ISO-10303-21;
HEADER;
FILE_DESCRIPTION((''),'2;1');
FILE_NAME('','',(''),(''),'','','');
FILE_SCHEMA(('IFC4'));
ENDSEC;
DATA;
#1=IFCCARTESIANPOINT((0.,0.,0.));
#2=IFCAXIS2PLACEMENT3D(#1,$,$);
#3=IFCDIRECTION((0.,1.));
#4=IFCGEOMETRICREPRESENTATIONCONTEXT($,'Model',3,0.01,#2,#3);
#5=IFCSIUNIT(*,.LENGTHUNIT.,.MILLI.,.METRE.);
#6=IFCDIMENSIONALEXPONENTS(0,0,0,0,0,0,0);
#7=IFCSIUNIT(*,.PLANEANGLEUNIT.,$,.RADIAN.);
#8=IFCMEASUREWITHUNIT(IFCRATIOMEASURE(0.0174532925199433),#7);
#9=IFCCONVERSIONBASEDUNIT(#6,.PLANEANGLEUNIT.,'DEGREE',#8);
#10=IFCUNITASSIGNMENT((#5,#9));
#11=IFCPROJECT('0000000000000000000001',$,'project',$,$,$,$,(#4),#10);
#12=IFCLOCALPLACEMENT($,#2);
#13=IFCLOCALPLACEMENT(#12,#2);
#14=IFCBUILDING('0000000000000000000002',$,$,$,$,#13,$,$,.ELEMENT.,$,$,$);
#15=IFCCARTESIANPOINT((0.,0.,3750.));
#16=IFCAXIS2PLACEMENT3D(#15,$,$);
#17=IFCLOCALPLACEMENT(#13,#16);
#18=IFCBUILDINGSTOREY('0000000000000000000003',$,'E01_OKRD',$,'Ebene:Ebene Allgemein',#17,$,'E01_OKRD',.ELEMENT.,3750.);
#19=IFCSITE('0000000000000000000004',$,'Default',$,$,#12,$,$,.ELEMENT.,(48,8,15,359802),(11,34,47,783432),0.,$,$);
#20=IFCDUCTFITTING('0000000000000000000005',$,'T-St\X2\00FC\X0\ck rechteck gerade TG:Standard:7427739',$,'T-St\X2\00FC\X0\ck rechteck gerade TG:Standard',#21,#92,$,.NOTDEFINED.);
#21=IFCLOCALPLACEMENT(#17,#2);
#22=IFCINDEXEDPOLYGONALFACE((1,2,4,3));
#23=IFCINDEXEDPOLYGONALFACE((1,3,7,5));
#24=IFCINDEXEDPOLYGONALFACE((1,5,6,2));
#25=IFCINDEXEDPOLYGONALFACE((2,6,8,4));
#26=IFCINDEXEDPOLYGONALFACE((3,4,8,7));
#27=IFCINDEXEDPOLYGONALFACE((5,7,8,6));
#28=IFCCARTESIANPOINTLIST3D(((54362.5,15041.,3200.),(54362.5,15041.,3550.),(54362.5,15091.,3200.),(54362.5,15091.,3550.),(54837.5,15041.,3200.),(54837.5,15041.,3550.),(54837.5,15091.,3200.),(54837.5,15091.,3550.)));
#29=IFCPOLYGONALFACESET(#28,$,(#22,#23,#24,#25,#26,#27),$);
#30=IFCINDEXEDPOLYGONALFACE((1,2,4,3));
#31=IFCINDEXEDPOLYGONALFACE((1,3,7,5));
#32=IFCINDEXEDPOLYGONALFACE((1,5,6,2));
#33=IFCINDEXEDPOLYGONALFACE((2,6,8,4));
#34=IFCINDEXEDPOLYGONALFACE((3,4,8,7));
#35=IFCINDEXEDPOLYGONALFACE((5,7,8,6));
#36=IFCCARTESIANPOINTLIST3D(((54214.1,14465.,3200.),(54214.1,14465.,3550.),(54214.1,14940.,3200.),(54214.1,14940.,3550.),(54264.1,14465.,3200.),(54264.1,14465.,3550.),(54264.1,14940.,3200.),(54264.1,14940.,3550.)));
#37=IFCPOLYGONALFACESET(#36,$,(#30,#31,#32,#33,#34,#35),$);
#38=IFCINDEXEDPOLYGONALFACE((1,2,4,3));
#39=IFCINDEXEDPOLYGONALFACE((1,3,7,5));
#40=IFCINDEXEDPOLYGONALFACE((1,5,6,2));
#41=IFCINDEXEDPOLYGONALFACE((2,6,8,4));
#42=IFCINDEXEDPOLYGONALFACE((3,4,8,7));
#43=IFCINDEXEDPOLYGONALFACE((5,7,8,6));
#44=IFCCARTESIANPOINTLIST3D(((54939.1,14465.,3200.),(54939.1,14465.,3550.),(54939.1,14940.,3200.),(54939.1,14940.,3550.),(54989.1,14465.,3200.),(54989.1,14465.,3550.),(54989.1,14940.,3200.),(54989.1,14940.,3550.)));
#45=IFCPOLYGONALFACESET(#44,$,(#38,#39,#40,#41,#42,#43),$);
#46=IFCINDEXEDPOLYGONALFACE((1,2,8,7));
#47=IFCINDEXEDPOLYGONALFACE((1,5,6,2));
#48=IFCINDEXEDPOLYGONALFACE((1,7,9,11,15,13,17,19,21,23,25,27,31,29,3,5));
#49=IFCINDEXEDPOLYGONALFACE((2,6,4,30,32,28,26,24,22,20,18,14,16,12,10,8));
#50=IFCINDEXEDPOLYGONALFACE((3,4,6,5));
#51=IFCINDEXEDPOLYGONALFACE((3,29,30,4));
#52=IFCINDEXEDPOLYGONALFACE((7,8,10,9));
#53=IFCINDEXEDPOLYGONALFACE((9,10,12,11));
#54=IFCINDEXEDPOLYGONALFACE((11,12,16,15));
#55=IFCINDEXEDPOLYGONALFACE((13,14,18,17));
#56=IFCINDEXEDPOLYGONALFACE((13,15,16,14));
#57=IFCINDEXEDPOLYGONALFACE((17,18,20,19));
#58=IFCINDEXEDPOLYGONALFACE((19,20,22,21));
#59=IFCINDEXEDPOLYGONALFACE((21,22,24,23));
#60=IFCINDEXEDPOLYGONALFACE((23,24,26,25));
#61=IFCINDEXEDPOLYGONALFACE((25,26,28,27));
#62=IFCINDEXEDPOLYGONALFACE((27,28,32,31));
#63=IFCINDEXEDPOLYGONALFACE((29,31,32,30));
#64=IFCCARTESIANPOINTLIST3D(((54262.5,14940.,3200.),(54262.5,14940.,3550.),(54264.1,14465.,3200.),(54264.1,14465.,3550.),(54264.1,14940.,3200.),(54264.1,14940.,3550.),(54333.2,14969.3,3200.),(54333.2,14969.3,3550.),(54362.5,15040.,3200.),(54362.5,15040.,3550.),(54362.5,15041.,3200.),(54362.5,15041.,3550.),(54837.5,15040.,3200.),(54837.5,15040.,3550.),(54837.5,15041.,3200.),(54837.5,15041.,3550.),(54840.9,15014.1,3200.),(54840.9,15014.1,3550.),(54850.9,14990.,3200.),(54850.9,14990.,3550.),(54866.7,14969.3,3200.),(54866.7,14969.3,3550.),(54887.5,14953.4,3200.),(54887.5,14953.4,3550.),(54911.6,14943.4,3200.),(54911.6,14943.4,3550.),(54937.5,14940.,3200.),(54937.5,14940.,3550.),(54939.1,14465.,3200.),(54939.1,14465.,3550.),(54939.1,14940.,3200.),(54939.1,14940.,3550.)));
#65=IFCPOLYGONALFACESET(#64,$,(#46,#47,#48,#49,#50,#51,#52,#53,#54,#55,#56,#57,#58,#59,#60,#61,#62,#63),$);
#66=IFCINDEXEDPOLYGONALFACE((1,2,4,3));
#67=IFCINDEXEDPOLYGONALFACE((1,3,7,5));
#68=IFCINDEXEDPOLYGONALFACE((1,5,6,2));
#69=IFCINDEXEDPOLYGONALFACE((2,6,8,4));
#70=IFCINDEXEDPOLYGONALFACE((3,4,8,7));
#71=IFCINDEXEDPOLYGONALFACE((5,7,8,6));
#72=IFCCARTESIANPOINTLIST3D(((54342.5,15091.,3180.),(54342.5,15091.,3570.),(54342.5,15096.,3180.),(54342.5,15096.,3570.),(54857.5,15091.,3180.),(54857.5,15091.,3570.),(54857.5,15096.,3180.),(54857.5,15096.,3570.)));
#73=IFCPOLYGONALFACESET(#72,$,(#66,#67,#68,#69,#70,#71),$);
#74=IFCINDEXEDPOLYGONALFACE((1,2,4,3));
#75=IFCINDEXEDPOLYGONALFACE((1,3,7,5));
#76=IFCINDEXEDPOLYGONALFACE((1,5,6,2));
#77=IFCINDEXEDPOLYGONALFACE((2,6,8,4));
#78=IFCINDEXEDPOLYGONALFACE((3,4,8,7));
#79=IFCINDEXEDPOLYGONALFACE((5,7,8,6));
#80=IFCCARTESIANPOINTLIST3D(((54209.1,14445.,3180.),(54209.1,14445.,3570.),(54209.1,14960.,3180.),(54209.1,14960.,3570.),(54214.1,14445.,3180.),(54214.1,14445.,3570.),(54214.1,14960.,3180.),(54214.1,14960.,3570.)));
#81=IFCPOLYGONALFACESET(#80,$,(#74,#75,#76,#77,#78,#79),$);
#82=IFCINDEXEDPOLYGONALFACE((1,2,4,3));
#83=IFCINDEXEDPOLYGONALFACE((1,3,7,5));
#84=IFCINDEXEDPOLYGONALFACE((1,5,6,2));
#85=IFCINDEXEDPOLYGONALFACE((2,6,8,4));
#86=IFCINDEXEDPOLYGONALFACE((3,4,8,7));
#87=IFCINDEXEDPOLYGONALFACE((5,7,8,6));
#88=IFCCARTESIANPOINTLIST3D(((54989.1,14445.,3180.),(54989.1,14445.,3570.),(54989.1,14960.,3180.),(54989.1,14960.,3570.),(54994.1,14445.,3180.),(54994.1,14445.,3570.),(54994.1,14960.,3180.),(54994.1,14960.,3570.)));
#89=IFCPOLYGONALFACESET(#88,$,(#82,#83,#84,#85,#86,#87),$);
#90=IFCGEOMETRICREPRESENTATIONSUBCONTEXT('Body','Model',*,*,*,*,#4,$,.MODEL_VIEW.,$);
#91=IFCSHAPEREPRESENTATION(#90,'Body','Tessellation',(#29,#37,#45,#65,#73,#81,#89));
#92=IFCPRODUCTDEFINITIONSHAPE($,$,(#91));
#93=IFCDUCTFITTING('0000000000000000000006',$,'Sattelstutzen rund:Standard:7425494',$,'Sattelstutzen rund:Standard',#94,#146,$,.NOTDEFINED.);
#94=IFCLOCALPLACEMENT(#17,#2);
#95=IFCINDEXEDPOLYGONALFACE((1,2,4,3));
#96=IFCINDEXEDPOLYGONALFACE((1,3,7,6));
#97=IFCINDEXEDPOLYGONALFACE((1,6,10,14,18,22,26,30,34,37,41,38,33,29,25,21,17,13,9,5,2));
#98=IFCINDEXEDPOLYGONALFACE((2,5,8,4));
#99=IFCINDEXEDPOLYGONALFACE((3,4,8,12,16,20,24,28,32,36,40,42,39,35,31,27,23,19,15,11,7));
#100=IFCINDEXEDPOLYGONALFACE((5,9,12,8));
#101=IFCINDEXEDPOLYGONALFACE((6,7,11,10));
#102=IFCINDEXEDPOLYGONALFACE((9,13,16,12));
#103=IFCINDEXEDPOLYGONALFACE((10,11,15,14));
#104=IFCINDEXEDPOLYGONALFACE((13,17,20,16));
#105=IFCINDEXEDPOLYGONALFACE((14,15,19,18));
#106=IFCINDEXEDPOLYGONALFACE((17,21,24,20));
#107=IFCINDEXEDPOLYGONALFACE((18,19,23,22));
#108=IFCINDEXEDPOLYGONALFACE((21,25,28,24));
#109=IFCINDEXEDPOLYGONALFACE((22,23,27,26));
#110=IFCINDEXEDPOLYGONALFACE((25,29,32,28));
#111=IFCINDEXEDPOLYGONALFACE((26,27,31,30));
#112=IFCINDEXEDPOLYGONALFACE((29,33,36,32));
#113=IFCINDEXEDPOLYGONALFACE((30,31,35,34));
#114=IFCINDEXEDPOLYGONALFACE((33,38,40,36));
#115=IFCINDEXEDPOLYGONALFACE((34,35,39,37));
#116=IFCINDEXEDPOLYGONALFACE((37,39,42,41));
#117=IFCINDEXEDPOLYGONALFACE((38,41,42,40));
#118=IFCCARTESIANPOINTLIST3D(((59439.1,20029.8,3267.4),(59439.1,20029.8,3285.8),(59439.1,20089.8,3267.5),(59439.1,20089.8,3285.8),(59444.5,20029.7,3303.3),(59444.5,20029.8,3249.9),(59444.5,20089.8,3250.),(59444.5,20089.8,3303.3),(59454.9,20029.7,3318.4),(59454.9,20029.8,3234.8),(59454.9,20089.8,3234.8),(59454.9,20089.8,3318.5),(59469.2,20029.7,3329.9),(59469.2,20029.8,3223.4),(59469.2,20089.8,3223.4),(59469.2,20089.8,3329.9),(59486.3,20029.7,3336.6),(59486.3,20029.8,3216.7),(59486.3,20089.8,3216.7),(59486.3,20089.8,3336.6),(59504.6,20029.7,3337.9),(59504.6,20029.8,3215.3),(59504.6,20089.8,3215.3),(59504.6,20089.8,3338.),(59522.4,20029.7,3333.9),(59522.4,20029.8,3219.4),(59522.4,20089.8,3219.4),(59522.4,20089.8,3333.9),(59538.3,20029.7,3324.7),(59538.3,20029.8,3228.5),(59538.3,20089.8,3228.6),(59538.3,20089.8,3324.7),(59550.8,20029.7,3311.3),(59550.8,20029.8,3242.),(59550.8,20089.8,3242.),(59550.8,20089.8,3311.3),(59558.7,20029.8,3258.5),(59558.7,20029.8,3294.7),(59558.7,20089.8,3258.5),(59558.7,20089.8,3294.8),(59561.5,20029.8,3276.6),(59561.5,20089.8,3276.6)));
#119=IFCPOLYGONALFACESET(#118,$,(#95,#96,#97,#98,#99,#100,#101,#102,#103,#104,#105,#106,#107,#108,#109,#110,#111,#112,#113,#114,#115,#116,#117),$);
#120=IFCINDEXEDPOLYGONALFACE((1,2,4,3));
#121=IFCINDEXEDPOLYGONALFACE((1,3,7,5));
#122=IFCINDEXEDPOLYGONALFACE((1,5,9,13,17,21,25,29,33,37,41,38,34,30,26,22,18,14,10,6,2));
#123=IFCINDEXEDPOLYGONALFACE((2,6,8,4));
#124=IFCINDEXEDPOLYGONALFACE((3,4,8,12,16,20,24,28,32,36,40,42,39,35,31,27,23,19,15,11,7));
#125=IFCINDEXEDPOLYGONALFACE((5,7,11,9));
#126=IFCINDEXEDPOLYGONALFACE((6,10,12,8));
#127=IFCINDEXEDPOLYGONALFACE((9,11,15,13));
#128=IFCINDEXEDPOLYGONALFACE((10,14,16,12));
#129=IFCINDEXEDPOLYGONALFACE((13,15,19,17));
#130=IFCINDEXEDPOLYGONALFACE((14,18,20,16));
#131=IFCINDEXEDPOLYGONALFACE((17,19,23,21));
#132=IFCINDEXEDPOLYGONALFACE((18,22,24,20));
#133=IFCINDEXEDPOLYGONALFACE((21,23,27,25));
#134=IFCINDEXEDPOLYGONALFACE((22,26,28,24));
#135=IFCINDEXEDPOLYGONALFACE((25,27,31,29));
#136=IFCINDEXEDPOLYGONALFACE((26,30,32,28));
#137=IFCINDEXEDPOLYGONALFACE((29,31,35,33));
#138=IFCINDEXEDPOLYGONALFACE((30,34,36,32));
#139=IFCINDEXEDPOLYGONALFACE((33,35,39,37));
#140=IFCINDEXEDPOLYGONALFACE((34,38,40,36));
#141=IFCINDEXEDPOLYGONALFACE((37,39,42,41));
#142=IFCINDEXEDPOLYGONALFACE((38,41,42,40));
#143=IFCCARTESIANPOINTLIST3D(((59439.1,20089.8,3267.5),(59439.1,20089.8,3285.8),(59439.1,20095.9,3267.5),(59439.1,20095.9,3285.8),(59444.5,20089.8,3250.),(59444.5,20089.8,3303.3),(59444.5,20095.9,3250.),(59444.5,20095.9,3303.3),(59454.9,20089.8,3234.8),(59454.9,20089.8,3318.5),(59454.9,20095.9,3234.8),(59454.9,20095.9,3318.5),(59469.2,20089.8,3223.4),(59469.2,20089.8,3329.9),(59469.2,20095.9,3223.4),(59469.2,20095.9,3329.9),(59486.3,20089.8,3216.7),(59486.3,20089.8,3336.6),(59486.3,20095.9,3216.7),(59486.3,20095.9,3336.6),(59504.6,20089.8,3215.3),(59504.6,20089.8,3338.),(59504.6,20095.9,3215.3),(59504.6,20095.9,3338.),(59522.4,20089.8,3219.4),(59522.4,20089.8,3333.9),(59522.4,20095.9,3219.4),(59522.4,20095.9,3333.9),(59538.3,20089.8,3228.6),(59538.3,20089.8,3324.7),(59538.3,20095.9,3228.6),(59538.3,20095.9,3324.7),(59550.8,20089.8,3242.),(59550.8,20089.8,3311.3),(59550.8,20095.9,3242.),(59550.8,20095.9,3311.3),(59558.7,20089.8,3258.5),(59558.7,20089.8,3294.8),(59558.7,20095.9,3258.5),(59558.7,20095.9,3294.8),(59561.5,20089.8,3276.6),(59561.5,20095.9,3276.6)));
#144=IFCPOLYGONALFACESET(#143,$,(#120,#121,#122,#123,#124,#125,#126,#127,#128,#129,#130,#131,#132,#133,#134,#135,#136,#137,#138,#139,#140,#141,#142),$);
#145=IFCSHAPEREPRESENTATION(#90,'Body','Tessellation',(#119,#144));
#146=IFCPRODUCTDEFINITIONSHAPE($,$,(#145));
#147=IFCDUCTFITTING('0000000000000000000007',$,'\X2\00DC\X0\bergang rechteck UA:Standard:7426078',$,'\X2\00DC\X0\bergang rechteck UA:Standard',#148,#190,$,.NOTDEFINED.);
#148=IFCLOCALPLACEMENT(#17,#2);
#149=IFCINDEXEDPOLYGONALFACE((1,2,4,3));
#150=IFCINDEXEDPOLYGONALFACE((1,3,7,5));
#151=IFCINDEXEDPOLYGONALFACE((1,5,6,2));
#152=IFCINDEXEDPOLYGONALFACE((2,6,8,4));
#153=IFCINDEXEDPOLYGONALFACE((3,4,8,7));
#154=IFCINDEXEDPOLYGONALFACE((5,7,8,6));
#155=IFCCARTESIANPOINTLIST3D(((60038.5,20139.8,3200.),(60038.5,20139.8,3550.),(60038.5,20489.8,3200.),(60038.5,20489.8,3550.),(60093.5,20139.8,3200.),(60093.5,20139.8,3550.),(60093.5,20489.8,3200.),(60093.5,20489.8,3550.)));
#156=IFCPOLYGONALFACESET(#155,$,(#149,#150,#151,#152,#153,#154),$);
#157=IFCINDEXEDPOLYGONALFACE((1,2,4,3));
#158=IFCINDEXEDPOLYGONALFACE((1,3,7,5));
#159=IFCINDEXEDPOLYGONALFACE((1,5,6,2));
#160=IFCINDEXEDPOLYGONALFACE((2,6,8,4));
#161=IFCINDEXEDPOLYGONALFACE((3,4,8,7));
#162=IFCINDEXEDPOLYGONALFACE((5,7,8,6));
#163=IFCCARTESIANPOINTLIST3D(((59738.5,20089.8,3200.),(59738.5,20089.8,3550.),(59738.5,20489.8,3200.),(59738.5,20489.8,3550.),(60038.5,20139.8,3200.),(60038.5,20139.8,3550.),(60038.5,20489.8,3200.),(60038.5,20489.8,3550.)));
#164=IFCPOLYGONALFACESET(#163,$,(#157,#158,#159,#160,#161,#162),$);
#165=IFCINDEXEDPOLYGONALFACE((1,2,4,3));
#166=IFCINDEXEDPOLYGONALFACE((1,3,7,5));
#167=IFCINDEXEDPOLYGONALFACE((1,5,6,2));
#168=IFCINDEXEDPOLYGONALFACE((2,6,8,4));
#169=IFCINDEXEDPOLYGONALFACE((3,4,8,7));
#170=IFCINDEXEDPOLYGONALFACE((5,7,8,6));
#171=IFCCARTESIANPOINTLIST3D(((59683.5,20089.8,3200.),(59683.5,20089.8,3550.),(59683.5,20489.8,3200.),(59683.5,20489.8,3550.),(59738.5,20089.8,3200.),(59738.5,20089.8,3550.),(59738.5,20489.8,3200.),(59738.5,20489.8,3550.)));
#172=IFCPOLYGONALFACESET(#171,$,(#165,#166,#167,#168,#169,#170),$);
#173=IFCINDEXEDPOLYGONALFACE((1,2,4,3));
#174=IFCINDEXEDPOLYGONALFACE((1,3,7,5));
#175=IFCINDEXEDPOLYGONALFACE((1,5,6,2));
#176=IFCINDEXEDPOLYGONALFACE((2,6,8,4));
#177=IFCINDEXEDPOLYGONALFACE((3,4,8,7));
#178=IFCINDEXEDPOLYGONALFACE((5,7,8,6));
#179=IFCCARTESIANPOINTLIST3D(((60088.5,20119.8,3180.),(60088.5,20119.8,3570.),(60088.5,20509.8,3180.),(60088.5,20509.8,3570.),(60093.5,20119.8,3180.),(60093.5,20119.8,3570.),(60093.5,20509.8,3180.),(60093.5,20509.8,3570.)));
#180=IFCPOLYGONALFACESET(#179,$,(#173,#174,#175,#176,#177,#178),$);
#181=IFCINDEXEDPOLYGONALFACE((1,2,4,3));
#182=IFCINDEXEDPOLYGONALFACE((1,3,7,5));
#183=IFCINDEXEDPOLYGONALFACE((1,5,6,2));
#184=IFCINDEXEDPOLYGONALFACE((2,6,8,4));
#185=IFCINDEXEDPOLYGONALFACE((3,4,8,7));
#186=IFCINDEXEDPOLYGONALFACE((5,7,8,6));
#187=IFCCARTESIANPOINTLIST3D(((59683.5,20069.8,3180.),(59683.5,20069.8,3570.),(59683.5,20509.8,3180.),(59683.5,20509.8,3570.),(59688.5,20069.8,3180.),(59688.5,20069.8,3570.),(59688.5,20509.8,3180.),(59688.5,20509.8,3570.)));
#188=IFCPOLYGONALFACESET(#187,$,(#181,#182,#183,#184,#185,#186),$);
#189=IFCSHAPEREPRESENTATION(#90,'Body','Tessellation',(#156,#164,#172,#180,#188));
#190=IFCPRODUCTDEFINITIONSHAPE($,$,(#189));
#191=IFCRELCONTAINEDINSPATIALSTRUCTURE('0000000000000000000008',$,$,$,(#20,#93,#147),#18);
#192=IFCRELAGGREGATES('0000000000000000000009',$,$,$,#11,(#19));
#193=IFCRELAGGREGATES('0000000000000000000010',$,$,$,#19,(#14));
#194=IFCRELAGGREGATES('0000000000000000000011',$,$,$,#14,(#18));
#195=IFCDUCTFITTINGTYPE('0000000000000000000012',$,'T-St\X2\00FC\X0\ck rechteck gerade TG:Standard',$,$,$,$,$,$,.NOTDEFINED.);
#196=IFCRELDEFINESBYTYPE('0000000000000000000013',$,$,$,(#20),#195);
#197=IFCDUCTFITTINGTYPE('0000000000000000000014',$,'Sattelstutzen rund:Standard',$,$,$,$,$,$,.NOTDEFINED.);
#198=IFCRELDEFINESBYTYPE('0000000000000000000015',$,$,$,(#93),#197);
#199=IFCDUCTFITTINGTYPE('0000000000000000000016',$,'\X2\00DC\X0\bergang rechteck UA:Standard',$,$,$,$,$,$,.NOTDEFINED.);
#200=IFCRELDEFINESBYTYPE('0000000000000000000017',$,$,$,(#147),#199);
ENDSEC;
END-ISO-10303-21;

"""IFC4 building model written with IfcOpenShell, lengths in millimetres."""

from ifc_helpers import new_model, entity, si_unit, converted_unit, direction, frame, frame_2d, origin, origin_2d_with_axis, place, context, subcontext, project, spatial, polyline, circle_curve, parameter, trimmed, segment, composite_curve, rectangle, circle, outline, extrude, source, transform, mapped, type_object, type_shapes, element, save


model = new_model("IFC4")

# Units and contexts
model_context = context("Model", 3, precision=0.01, world=origin(), true_north=direction((0.0, 1.0)))
body_context = subcontext(model_context, "Body", "Model", "MODEL_VIEW")
ifc_project = project(units=[si_unit("LENGTHUNIT", "METRE", prefix="MILLI"), converted_unit("PLANEANGLEUNIT", "DEGREE", entity("IfcRatioMeasure", 0.0174532925199433), si_unit("PLANEANGLEUNIT", "RADIAN"), dimensions=[0, 0, 0, 0, 0, 0, 0])], contexts=[model_context])

# Site, building, storey
site_placement = place(None, origin())
site = spatial("IfcSite", under=ifc_project, at=site_placement, Name="Default", CompositionType="ELEMENT", RefLatitude=(48, 8, 15, 359802), RefLongitude=(11, 34, 47, 783432), RefElevation=0.0)
building_placement = place(site_placement, origin())
building = spatial("IfcBuilding", under=site, at=building_placement, CompositionType="ELEMENT")
storey_placement = place(building_placement, frame((0.0, 0.0, 3750.0)))
storey = spatial("IfcBuildingStorey", under=building, at=storey_placement, Name="E01_OKRD", ObjectType="Ebene:Ebene Allgemein", LongName="E01_OKRD", CompositionType="ELEMENT", Elevation=3750.0)

# Duct fittings
duct_fitting_type_1 = type_object("IfcDuctFittingType", Name="T-Stück rechteck gerade TG:Standard", PredefinedType="NOTDEFINED")
shared_shape_1 = source(origin(), body_context, "Body", "SweptSolid", [
    extrude(rectangle(XDim=50.0, YDim=475.0, at=origin_2d_with_axis()), frame((0.0, -363.5, -175.0), z_axis=(0.0, 0.0, 1.0), x_axis=(0.0, -1.0, 0.0)), (0.0, 0.0, 1.0), 350.0),
    extrude(rectangle(XDim=50.0, YDim=475.0, at=origin_2d_with_axis()), frame((360.9, 0.0, -175.0), z_axis=(0.0, 0.0, 1.0), x_axis=(-1.0, 0.0, 0.0)), (0.0, 0.0, 1.0), 350.0),
    extrude(rectangle(XDim=50.0, YDim=475.0, at=origin_2d_with_axis()), frame((-364.1, 0.0, -175.0)), (0.0, 0.0, 1.0), 350.0),
    extrude(outline(composite_curve([segment(trimmed(circle_curve(frame_2d((-338.1, -154.8), x_axis=(-1.0, 0.0)), 100.0), [parameter(180.0)], [parameter(270.0)], True, "PARAMETER"), False, "CONTINUOUS"), segment(polyline([(-238.1, -154.8), (-238.1, -155.8)]), True, "CONTINUOUS"), segment(polyline([(-238.1, -155.8), (236.9, -155.8)]), True, "CONTINUOUS"), segment(polyline([(236.9, -155.8), (236.9, -154.8)]), True, "CONTINUOUS"), segment(trimmed(circle_curve(frame_2d((336.9, -154.8), x_axis=(-1.0, 0.0)), 100.0), [parameter(270.0)], [parameter(0.0)], True, "PARAMETER"), False, "CONTINUOUS"), segment(polyline([(336.9, -54.8), (338.5, -54.8)]), True, "CONTINUOUS"), segment(polyline([(338.5, -54.8), (338.5, 420.2)]), True, "CONTINUOUS"), segment(polyline([(338.5, 420.2), (-336.5, 420.2)]), True, "CONTINUOUS"), segment(polyline([(-336.5, 420.2), (-336.5, -54.8)]), True, "CONTINUOUS"), segment(polyline([(-336.5, -54.8), (-338.1, -54.8)]), True, "CONTINUOUS")], self_intersect=False)), frame((-0.6, -182.7, -175.0), z_axis=(0.0, 0.0, -1.0), x_axis=(-1.0, 0.0, 0.0)), (0.0, 0.0, -1.0), 350.0),
    extrude(rectangle(XDim=5.0, YDim=515.0, at=origin_2d_with_axis()), frame((0.0, -391.0, -195.0), z_axis=(0.0, 0.0, 1.0), x_axis=(0.0, 1.0, 0.0)), (0.0, 0.0, 1.0), 390.0),
    extrude(rectangle(XDim=5.0, YDim=515.0, at=origin_2d_with_axis()), frame((388.4, 0.0, -195.0), z_axis=(0.0, 0.0, 1.0), x_axis=(-1.0, 0.0, 0.0)), (0.0, 0.0, 1.0), 390.0),
    extrude(rectangle(XDim=5.0, YDim=515.0, at=origin_2d_with_axis()), frame((-391.6, 0.0, -195.0), z_axis=(0.0, 0.0, 1.0), x_axis=(-1.0, 0.0, 0.0)), (0.0, 0.0, 1.0), 390.0),
])
type_shapes(duct_fitting_type_1, [shared_shape_1])
duct_fitting_1_placement = place(storey_placement, frame((54600.0, 14702.5, 3375.0), z_axis=(0.0, 0.0, 1.0), x_axis=(-1.0, 0.0, 0.0)))
element("IfcDuctFitting", 1, at=duct_fitting_1_placement, inside=storey, type_object=duct_fitting_type_1, Name="T-Stück rechteck gerade TG:Standard:7427739", ObjectType="T-Stück rechteck gerade TG:Standard", PredefinedType="NOTDEFINED", context=body_context, shape_type="MappedRepresentation", body=[
    mapped(shared_shape_1, transform((0.0, 0.0, 0.0), scale=1.0)),
])
duct_fitting_type_2 = type_object("IfcDuctFittingType", Name="Sattelstutzen rund:Standard", PredefinedType="NOTDEFINED")
shared_shape_2 = source(origin(), body_context, "Body", "SweptSolid", [
    extrude(circle(Radius=61.5, at=frame_2d((0.0, 0.0), x_axis=(1.0, 0.0))), frame((0.0, 0.0, 0.0), z_axis=(1.0, 0.0, 0.0), x_axis=(0.0, -1.0, 0.0)), (0.0, 0.0, 1.0), 60.0),
    extrude(circle(Radius=61.5, at=frame_2d((0.0, 0.0), x_axis=(1.0, 0.0))), frame((-6.1, 0.0, 0.0), z_axis=(1.0, 0.0, 0.0), x_axis=(0.0, -1.0, 0.0)), (0.0, 0.0, 1.0), 6.1),
])
type_shapes(duct_fitting_type_2, [shared_shape_2])
duct_fitting_2_placement = place(storey_placement, frame((59500.0, 20089.8, 3276.6), z_axis=(0.0, 0.000429, -1.0), x_axis=(0.0, -1.0, -0.000429)))
element("IfcDuctFitting", 2, at=duct_fitting_2_placement, inside=storey, type_object=duct_fitting_type_2, Name="Sattelstutzen rund:Standard:7425494", ObjectType="Sattelstutzen rund:Standard", PredefinedType="NOTDEFINED", context=body_context, shape_type="MappedRepresentation", body=[
    mapped(shared_shape_2, transform((0.0, 0.0, 0.0), scale=1.0)),
])
duct_fitting_type_3 = type_object("IfcDuctFittingType", Name="Übergang rechteck UA:Standard", PredefinedType="NOTDEFINED")
shared_shape_3 = source(origin(), body_context, "Body", "SweptSolid", [
    extrude(rectangle(XDim=55.0, YDim=350.0, at=origin_2d_with_axis()), frame((382.5, 25.0, -175.0)), (0.0, 0.0, 1.0), 350.0),
    extrude(outline(polyline([(-182.9, -184.9), (121.2, -184.9), (178.8, 160.3), (-117.1, 209.6), (-182.9, -184.9)])), frame((205.0, 12.5, -175.0), z_axis=(0.0, 0.0, 1.0), x_axis=(0.986394, 0.164399, 0.0)), (0.0, 0.0, 1.0), 350.0),
    extrude(rectangle(XDim=55.0, YDim=400.0, at=frame_2d((0.0, 0.0), x_axis=(1.0, 0.0))), frame((27.5, 0.0, -175.0)), (0.0, 0.0, 1.0), 350.0),
    extrude(rectangle(XDim=5.0, YDim=390.0, at=origin_2d_with_axis()), frame((407.5, 25.0, -195.0)), (0.0, 0.0, 1.0), 390.0),
    extrude(rectangle(XDim=5.0, YDim=440.0, at=frame_2d((0.0, 0.0), x_axis=(1.0, 0.0))), frame((2.5, 0.0, -195.0)), (0.0, 0.0, 1.0), 390.0),
])
type_shapes(duct_fitting_type_3, [shared_shape_3])
duct_fitting_3_placement = place(storey_placement, frame((59683.5, 20289.8, 3375.0)))
element("IfcDuctFitting", 3, at=duct_fitting_3_placement, inside=storey, type_object=duct_fitting_type_3, Name="Übergang rechteck UA:Standard:7426078", ObjectType="Übergang rechteck UA:Standard", PredefinedType="NOTDEFINED", context=body_context, shape_type="MappedRepresentation", body=[
    mapped(shared_shape_3, transform((0.0, 0.0, 0.0), scale=1.0)),
])

save(model, "model.ifc")
